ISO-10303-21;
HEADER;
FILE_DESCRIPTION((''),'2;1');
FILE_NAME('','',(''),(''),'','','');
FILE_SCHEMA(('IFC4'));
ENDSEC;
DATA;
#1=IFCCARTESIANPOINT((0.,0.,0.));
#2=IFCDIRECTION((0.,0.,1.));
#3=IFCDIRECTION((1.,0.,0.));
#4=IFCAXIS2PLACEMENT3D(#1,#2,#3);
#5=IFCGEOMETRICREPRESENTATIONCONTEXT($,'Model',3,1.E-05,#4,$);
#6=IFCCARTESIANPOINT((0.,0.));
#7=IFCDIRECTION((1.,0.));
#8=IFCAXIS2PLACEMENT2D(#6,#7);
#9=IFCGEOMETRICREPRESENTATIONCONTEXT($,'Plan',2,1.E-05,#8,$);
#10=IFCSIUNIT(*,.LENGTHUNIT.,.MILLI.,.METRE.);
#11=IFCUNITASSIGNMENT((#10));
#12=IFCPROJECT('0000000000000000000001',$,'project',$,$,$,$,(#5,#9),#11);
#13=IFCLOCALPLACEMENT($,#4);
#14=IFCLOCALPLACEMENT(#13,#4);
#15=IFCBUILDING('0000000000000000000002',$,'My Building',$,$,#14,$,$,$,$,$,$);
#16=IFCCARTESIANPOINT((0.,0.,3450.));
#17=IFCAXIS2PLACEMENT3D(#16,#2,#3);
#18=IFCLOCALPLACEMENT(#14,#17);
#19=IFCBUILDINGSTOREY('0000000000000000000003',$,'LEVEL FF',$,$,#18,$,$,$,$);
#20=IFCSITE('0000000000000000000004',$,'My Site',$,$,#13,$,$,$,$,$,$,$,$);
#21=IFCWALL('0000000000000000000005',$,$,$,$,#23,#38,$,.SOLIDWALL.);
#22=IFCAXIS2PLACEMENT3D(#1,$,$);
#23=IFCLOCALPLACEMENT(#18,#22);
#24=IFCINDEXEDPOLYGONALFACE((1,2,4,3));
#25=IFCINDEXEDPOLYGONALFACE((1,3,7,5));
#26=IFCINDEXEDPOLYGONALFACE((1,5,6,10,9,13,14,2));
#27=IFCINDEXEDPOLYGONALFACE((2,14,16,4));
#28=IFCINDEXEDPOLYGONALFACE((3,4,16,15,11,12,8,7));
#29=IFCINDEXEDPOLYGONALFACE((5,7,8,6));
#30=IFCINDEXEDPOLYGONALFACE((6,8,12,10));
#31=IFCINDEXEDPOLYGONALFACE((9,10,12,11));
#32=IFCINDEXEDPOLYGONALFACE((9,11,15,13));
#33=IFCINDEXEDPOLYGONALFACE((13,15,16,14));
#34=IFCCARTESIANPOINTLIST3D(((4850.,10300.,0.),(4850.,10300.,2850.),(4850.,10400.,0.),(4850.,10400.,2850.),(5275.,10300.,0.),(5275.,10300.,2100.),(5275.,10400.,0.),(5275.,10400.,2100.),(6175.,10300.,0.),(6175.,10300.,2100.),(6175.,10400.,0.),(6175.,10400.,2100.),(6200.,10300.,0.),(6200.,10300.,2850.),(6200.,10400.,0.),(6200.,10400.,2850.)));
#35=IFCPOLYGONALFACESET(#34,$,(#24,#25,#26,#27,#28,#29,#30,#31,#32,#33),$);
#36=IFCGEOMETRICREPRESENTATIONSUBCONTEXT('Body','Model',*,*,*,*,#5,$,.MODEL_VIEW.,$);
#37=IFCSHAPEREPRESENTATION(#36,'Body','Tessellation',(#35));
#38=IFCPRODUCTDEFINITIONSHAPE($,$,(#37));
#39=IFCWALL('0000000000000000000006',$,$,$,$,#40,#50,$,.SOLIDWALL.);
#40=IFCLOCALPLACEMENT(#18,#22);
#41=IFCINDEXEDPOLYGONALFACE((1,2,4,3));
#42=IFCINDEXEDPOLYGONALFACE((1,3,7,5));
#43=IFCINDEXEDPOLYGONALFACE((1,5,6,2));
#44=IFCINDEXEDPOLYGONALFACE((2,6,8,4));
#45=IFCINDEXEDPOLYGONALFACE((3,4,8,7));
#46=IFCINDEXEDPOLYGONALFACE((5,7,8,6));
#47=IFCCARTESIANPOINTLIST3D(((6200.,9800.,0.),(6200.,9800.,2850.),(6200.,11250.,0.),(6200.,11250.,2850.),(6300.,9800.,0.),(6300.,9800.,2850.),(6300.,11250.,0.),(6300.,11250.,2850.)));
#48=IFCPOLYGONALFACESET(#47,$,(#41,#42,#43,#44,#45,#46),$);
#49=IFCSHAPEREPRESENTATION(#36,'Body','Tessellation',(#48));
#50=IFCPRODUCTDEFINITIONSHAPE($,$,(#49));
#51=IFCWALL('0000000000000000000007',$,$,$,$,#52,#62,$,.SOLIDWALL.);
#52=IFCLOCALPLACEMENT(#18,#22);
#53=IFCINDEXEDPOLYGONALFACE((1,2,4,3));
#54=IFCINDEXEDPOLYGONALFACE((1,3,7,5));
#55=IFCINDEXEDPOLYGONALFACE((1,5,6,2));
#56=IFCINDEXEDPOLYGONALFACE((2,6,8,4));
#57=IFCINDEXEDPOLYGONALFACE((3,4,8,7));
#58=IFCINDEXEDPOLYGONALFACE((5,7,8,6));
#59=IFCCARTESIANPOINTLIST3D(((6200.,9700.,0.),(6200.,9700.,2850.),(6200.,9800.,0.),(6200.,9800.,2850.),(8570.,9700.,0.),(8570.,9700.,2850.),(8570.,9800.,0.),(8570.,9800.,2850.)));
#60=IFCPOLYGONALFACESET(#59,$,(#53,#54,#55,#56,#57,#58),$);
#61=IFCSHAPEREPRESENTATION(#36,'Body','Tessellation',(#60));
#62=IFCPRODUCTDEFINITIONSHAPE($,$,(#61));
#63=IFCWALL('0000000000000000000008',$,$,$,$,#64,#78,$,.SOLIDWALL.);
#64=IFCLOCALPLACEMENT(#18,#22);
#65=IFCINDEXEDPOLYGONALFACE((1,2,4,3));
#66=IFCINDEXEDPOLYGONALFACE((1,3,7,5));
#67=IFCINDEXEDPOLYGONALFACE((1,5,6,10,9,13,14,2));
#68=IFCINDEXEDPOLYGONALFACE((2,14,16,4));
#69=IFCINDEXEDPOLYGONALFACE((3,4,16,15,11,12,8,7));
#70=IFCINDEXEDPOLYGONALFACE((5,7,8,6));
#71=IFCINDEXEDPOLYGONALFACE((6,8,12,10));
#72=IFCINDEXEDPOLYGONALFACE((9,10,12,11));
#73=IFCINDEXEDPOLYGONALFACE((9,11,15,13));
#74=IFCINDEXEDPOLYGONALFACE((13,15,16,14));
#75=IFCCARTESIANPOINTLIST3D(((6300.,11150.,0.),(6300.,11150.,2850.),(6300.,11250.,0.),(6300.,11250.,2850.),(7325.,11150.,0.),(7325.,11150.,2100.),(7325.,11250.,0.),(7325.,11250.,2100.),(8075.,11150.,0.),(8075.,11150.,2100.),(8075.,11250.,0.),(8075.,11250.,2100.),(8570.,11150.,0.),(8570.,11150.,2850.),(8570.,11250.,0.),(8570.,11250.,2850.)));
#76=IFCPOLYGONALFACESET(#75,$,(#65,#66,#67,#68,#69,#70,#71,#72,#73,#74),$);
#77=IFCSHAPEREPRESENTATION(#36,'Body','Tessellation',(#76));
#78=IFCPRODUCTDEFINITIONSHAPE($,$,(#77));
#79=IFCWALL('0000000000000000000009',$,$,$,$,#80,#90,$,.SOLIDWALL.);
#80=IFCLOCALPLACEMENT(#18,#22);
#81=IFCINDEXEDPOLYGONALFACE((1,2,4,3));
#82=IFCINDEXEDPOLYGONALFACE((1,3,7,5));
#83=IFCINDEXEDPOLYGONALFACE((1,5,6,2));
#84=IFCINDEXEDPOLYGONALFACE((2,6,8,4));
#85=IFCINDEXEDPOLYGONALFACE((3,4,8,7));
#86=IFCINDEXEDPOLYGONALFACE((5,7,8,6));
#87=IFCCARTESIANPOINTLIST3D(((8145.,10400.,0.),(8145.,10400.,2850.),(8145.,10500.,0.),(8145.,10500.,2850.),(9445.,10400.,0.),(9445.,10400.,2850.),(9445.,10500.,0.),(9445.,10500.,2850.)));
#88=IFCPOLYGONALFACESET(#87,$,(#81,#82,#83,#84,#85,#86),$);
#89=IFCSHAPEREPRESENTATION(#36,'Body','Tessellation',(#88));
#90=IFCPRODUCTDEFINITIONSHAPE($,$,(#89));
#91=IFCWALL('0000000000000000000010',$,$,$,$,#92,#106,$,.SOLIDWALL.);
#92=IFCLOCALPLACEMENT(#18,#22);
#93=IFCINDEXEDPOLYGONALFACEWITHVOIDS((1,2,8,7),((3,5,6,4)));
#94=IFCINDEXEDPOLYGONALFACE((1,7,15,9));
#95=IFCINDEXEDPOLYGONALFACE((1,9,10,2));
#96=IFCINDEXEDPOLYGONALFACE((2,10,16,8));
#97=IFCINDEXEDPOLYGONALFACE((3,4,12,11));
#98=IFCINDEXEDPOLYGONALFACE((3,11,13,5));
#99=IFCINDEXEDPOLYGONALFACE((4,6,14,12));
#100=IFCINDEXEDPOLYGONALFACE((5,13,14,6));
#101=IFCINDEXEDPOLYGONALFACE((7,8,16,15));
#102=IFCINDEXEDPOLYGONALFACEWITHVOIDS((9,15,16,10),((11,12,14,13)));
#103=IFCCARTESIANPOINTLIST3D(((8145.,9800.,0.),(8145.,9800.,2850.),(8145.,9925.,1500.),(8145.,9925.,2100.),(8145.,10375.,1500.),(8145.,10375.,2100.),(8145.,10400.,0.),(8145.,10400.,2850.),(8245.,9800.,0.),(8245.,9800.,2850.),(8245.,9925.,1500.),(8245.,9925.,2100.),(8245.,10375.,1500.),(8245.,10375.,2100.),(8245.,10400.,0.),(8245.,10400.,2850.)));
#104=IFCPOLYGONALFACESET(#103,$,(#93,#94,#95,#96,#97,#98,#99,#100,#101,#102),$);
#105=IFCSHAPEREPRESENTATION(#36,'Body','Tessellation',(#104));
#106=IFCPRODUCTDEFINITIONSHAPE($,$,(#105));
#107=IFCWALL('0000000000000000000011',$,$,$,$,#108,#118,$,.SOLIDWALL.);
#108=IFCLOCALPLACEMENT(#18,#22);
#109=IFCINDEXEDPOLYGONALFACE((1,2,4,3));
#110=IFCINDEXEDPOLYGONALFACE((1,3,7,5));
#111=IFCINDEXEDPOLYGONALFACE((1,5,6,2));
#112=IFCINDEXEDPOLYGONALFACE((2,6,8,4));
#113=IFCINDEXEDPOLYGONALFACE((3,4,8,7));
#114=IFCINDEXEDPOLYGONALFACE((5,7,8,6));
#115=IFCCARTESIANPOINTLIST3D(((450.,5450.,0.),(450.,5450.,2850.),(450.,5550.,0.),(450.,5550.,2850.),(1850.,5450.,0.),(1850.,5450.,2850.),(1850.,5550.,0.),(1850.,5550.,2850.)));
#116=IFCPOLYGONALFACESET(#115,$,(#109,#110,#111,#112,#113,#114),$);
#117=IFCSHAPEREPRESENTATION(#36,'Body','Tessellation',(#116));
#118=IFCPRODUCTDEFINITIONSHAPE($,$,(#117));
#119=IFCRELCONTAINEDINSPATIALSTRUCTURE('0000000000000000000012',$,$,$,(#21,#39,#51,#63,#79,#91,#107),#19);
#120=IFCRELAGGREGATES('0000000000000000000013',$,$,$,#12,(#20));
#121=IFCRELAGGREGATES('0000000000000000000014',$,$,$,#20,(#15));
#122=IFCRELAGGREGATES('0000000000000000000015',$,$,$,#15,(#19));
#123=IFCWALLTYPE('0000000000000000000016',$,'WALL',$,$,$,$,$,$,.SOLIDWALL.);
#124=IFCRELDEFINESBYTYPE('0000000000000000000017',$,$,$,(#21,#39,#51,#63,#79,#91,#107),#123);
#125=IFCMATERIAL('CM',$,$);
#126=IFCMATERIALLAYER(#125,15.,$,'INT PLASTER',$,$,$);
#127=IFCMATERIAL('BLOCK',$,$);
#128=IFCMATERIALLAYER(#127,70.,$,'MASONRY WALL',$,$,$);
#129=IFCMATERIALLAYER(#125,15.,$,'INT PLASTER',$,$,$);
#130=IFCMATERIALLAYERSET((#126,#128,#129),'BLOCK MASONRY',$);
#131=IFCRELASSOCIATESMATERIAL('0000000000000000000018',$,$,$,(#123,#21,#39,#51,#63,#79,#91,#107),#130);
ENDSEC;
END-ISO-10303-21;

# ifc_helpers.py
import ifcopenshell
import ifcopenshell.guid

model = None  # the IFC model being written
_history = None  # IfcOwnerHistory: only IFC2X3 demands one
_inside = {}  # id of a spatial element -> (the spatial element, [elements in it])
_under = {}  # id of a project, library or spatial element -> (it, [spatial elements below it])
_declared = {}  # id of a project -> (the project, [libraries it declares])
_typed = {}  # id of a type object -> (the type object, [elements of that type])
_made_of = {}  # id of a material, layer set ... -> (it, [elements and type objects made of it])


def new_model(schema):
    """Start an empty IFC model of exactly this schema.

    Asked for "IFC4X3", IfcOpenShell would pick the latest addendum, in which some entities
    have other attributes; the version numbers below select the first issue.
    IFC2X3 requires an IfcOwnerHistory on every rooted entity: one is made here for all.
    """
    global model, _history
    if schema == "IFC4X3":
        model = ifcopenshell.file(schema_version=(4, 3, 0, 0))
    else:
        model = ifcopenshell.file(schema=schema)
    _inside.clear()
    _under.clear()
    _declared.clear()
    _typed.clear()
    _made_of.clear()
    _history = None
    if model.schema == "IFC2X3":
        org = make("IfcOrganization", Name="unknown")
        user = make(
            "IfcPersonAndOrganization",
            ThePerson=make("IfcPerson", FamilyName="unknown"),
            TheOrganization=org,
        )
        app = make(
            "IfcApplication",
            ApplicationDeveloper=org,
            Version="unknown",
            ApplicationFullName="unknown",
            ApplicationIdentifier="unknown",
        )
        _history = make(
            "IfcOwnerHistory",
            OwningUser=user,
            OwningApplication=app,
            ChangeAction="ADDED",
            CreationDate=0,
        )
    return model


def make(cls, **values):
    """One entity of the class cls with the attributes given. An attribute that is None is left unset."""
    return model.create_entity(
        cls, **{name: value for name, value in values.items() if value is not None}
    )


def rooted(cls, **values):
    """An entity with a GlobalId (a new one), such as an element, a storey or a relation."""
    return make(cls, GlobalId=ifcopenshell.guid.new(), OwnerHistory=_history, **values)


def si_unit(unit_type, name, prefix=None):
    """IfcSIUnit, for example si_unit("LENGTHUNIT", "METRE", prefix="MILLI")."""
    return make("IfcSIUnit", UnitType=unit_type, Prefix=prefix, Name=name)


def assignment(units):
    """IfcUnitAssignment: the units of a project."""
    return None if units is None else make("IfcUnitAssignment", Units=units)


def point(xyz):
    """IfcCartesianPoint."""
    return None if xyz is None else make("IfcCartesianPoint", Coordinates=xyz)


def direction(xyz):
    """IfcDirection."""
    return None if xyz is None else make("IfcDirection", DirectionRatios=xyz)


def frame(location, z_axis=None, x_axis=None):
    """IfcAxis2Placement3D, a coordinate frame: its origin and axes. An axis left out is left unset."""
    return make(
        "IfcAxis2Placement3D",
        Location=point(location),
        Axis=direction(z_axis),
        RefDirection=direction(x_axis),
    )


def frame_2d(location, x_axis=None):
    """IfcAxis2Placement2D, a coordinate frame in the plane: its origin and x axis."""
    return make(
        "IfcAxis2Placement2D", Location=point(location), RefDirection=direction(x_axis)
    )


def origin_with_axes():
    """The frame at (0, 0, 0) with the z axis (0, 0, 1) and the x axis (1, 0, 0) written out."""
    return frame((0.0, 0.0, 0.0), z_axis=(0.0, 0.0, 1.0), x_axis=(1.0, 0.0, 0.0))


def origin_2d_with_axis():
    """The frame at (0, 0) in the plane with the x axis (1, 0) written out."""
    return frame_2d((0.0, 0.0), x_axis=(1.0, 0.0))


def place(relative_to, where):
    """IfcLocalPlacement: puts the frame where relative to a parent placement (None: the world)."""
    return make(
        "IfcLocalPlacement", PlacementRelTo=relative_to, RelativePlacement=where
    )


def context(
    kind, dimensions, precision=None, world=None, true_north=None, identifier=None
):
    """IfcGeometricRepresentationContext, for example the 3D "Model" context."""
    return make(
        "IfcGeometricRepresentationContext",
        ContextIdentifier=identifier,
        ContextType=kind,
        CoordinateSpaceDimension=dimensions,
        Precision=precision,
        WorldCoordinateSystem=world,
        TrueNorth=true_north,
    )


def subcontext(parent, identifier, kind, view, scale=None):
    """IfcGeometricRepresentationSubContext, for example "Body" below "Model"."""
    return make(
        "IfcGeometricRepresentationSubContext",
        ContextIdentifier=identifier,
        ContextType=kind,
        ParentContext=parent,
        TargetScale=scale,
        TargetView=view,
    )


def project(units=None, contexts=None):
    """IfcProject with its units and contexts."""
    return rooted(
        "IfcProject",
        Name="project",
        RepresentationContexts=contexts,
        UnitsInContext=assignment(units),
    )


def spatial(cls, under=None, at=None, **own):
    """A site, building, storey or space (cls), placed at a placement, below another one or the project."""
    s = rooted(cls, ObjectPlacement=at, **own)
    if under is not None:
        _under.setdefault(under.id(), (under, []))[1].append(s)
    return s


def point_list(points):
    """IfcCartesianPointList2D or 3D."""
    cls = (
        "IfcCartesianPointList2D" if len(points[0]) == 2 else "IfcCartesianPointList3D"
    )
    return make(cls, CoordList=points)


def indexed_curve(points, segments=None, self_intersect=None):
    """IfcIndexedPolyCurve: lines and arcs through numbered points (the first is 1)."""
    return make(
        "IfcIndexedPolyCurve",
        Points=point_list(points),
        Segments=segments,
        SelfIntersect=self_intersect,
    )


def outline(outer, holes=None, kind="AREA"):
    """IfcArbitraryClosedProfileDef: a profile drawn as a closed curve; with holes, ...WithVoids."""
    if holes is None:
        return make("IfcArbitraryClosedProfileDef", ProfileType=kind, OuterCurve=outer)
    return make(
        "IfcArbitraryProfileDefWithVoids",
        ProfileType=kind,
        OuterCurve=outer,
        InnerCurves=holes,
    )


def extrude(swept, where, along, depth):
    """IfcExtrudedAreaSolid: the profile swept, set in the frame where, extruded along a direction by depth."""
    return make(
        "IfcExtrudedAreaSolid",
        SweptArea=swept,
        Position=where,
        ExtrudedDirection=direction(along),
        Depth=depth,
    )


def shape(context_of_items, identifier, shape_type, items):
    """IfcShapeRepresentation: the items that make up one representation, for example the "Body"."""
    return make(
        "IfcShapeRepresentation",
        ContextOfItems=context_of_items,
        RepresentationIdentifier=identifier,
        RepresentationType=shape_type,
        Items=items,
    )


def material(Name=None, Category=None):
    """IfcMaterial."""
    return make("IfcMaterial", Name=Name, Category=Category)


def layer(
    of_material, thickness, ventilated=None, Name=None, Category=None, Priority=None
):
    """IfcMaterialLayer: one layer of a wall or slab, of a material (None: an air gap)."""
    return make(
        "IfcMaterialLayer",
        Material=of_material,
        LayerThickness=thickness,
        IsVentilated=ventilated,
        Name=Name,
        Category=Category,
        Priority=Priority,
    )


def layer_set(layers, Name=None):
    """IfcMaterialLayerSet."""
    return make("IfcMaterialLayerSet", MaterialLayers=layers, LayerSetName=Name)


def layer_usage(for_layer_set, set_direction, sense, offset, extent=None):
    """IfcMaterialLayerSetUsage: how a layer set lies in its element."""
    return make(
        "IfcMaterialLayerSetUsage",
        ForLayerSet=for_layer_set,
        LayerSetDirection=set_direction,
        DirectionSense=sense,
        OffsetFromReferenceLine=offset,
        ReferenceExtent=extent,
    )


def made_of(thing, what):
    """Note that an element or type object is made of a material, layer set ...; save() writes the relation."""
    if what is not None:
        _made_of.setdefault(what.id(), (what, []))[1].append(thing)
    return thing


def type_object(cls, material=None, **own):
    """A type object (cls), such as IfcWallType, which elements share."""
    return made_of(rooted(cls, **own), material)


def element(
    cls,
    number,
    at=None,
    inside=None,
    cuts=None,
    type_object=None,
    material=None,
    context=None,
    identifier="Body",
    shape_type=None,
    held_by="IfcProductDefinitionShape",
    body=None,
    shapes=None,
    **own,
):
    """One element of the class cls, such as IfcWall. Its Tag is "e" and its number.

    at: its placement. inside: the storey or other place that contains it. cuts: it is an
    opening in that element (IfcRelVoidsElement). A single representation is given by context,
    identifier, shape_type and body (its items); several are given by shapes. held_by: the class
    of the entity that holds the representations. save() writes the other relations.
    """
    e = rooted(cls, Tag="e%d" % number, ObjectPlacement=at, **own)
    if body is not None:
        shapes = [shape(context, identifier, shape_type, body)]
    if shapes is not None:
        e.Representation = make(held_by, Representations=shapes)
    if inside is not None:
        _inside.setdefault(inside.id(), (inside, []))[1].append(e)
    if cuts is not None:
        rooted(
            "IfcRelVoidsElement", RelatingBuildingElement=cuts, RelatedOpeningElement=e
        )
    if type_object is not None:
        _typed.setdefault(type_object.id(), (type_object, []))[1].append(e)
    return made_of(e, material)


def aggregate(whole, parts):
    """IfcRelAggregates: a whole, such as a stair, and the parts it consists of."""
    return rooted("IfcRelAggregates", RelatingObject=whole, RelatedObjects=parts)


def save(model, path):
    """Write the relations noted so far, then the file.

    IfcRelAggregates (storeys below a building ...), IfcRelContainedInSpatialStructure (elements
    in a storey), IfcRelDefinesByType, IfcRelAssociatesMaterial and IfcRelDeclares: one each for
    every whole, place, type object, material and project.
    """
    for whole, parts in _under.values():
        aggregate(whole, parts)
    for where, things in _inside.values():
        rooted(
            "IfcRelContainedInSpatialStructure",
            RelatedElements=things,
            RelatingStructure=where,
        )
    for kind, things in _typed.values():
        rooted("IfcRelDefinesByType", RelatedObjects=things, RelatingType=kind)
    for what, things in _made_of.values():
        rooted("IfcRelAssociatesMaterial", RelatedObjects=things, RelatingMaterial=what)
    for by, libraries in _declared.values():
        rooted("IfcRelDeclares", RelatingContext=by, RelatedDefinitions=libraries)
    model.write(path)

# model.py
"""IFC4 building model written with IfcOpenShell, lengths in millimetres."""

from ifc_helpers import new_model, si_unit, frame, origin_with_axes, origin_2d_with_axis, place, context, subcontext, project, spatial, indexed_curve, outline, extrude, material, layer, layer_set, layer_usage, type_object, element, save


model = new_model("IFC4")

# Units and contexts
model_context = context("Model", 3, precision=1e-05, world=origin_with_axes())
plan_context = context("Plan", 2, precision=1e-05, world=origin_2d_with_axis())
body_context = subcontext(model_context, "Body", "Model", "MODEL_VIEW")
ifc_project = project(units=[si_unit("LENGTHUNIT", "METRE", prefix="MILLI")], contexts=[model_context, plan_context])

# Site, building, storey
site_placement = place(None, origin_with_axes())
site = spatial("IfcSite", under=ifc_project, at=site_placement, Name="My Site")
building_placement = place(site_placement, origin_with_axes())
building = spatial("IfcBuilding", under=site, at=building_placement, Name="My Building")
storey_placement = place(building_placement, frame((0.0, 0.0, 3450.0), z_axis=(0.0, 0.0, 1.0), x_axis=(1.0, 0.0, 0.0)))
storey = spatial("IfcBuildingStorey", under=building, at=storey_placement, Name="LEVEL FF")

# Shared definitions
ifc_material_1 = material(Name="CM")
ifc_layer_1 = layer(ifc_material_1, 15.0, Name="INT PLASTER")
ifc_material_2 = material(Name="BLOCK")
ifc_layer_2 = layer(ifc_material_2, 70.0, Name="MASONRY WALL")
ifc_layer_3 = layer(ifc_material_1, 15.0, Name="INT PLASTER")
ifc_layer_set = layer_set([ifc_layer_1, ifc_layer_2, ifc_layer_3], Name="BLOCK MASONRY")
wall_type = type_object("IfcWallType", Name="WALL", PredefinedType="SOLIDWALL", material=ifc_layer_set)

# Wall, opening
ifc_layer_usage_1 = layer_usage(ifc_layer_set, "AXIS2", "POSITIVE", 0.0)
wall_1_placement = place(storey_placement, frame((4850.0, 10400.0, 0.0), z_axis=(0.0, 0.0, 1.0), x_axis=(0.0, -1.0, 0.0)))
wall_1 = element("IfcWall", 1, at=wall_1_placement, inside=storey, type_object=wall_type, material=ifc_layer_usage_1, PredefinedType="SOLIDWALL", context=body_context, shape_type="SweptSolid", body=[
    extrude(outline(indexed_curve([(0.0, 0.0), (0.0, 1350.0), (100.0, 1350.0), (100.0, 0.0), (0.0, 0.0)], self_intersect=False)), origin_with_axes(), (0.0, 0.0, 1.0), 2850.0),
])
opening_1_placement = place(wall_1_placement, frame((100.0, 425.0, 0.0), z_axis=(0.0, 0.0, 1.0), x_axis=(0.0, 1.0, 0.0)))
element("IfcOpeningElement", 2, at=opening_1_placement, cuts=wall_1, PredefinedType="OPENING", context=body_context, shape_type="SweptSolid", body=[
    extrude(outline(indexed_curve([(0.0, 0.0), (0.0, 400.0), (900.0, 400.0), (900.0, 0.0), (0.0, 0.0)], self_intersect=False)), frame((0.0, -100.0, 0.0), z_axis=(0.0, 0.0, 1.0), x_axis=(1.0, 0.0, 0.0)), (0.0, 0.0, 1.0), 2100.0),
])

# Walls
ifc_layer_usage_2 = layer_usage(ifc_layer_set, "AXIS2", "POSITIVE", 0.0)
wall_2_placement = place(storey_placement, frame((6300.0, 9800.0, 0.0), z_axis=(0.0, 0.0, 1.0), x_axis=(0.0, 1.0, 0.0)))
element("IfcWall", 3, at=wall_2_placement, inside=storey, type_object=wall_type, material=ifc_layer_usage_2, PredefinedType="SOLIDWALL", context=body_context, shape_type="SweptSolid", body=[
    extrude(outline(indexed_curve([(0.0, 0.0), (0.0, 100.0), (1450.0, 100.0), (1450.0, 0.0), (0.0, 0.0)], self_intersect=False)), origin_with_axes(), (0.0, 0.0, 1.0), 2850.0),
])
ifc_layer_usage_3 = layer_usage(ifc_layer_set, "AXIS2", "POSITIVE", 0.0)
wall_3_placement = place(storey_placement, frame((6200.0, 9800.0, 0.0), z_axis=(0.0, 0.0, 1.0), x_axis=(0.0, -1.0, 0.0)))
element("IfcWall", 4, at=wall_3_placement, inside=storey, type_object=wall_type, material=ifc_layer_usage_3, PredefinedType="SOLIDWALL", context=body_context, shape_type="SweptSolid", body=[
    extrude(outline(indexed_curve([(0.0, 0.0), (0.0, 2370.0), (100.0, 2370.0), (100.0, 0.0), (0.0, 0.0)], self_intersect=False)), origin_with_axes(), (0.0, 0.0, 1.0), 2850.0),
])

# Wall, opening
ifc_layer_usage_4 = layer_usage(ifc_layer_set, "AXIS2", "POSITIVE", 0.0)
wall_4_placement = place(storey_placement, frame((6300.0, 11250.0, 0.0), z_axis=(0.0, 0.0, 1.0), x_axis=(0.0, -1.0, 0.0)))
wall_4 = element("IfcWall", 5, at=wall_4_placement, inside=storey, type_object=wall_type, material=ifc_layer_usage_4, PredefinedType="SOLIDWALL", context=body_context, shape_type="SweptSolid", body=[
    extrude(outline(indexed_curve([(0.0, 0.0), (0.0, 2270.0), (100.0, 2270.0), (100.0, 0.0), (0.0, 0.0)], self_intersect=False)), origin_with_axes(), (0.0, 0.0, 1.0), 2850.0),
])
opening_2_placement = place(wall_4_placement, frame((0.0, 1775.0, 0.0), z_axis=(0.0, 0.0, 1.0), x_axis=(0.0, -1.0, 0.0)))
element("IfcOpeningElement", 6, at=opening_2_placement, cuts=wall_4, PredefinedType="OPENING", context=body_context, shape_type="SweptSolid", body=[
    extrude(outline(indexed_curve([(0.0, 0.0), (0.0, 400.0), (750.0, 400.0), (750.0, 0.0), (0.0, 0.0)], self_intersect=False)), frame((0.0, -100.0, 0.0), z_axis=(0.0, 0.0, 1.0), x_axis=(1.0, 0.0, 0.0)), (0.0, 0.0, 1.0), 2100.0),
])

# Wall
ifc_layer_usage_5 = layer_usage(ifc_layer_set, "AXIS2", "POSITIVE", 0.0)
wall_5_placement = place(storey_placement, frame((8145.0, 10500.0, 0.0), z_axis=(0.0, 0.0, 1.0), x_axis=(0.0, -1.0, 0.0)))
element("IfcWall", 7, at=wall_5_placement, inside=storey, type_object=wall_type, material=ifc_layer_usage_5, PredefinedType="SOLIDWALL", context=body_context, shape_type="SweptSolid", body=[
    extrude(outline(indexed_curve([(0.0, 0.0), (0.0, 1300.0), (100.0, 1300.0), (100.0, 0.0), (0.0, 0.0)], self_intersect=False)), origin_with_axes(), (0.0, 0.0, 1.0), 2850.0),
])

# Wall, opening
ifc_layer_usage_6 = layer_usage(ifc_layer_set, "AXIS2", "POSITIVE", 0.0)
wall_6_placement = place(storey_placement, frame((8245.0, 9800.0, 0.0), z_axis=(0.0, 0.0, 1.0), x_axis=(0.0, 1.0, 0.0)))
wall_6 = element("IfcWall", 8, at=wall_6_placement, inside=storey, type_object=wall_type, material=ifc_layer_usage_6, PredefinedType="SOLIDWALL", context=body_context, shape_type="SweptSolid", body=[
    extrude(outline(indexed_curve([(0.0, 0.0), (0.0, 100.0), (600.0, 100.0), (600.0, 0.0), (0.0, 0.0)], self_intersect=False)), origin_with_axes(), (0.0, 0.0, 1.0), 2850.0),
])
opening_3_placement = place(wall_6_placement, frame((575.0, 100.0, 1500.0), z_axis=(0.0, 0.0, 1.0), x_axis=(-1.0, 0.0, 0.0)))
element("IfcOpeningElement", 9, at=opening_3_placement, cuts=wall_6, PredefinedType="OPENING", context=body_context, shape_type="SweptSolid", body=[
    extrude(outline(indexed_curve([(0.0, 0.0), (0.0, 400.0), (450.0, 400.0), (450.0, 0.0), (0.0, 0.0)], self_intersect=False)), frame((0.0, -100.0, 0.0), z_axis=(0.0, 0.0, 1.0), x_axis=(1.0, 0.0, 0.0)), (0.0, 0.0, 1.0), 600.0),
])

# Wall
ifc_layer_usage_7 = layer_usage(ifc_layer_set, "AXIS2", "POSITIVE", 0.0)
wall_7_placement = place(storey_placement, frame((450.0, 5550.0, 0.0), z_axis=(0.0, 0.0, 1.0), x_axis=(0.0, -1.0, 0.0)))
element("IfcWall", 10, at=wall_7_placement, inside=storey, type_object=wall_type, material=ifc_layer_usage_7, PredefinedType="SOLIDWALL", context=body_context, shape_type="SweptSolid", body=[
    extrude(outline(indexed_curve([(0.0, 0.0), (0.0, 1400.0), (100.0, 1400.0), (100.0, 0.0), (0.0, 0.0)], self_intersect=False)), origin_with_axes(), (0.0, 0.0, 1.0), 2850.0),
])

save(model, "model.ifc")
